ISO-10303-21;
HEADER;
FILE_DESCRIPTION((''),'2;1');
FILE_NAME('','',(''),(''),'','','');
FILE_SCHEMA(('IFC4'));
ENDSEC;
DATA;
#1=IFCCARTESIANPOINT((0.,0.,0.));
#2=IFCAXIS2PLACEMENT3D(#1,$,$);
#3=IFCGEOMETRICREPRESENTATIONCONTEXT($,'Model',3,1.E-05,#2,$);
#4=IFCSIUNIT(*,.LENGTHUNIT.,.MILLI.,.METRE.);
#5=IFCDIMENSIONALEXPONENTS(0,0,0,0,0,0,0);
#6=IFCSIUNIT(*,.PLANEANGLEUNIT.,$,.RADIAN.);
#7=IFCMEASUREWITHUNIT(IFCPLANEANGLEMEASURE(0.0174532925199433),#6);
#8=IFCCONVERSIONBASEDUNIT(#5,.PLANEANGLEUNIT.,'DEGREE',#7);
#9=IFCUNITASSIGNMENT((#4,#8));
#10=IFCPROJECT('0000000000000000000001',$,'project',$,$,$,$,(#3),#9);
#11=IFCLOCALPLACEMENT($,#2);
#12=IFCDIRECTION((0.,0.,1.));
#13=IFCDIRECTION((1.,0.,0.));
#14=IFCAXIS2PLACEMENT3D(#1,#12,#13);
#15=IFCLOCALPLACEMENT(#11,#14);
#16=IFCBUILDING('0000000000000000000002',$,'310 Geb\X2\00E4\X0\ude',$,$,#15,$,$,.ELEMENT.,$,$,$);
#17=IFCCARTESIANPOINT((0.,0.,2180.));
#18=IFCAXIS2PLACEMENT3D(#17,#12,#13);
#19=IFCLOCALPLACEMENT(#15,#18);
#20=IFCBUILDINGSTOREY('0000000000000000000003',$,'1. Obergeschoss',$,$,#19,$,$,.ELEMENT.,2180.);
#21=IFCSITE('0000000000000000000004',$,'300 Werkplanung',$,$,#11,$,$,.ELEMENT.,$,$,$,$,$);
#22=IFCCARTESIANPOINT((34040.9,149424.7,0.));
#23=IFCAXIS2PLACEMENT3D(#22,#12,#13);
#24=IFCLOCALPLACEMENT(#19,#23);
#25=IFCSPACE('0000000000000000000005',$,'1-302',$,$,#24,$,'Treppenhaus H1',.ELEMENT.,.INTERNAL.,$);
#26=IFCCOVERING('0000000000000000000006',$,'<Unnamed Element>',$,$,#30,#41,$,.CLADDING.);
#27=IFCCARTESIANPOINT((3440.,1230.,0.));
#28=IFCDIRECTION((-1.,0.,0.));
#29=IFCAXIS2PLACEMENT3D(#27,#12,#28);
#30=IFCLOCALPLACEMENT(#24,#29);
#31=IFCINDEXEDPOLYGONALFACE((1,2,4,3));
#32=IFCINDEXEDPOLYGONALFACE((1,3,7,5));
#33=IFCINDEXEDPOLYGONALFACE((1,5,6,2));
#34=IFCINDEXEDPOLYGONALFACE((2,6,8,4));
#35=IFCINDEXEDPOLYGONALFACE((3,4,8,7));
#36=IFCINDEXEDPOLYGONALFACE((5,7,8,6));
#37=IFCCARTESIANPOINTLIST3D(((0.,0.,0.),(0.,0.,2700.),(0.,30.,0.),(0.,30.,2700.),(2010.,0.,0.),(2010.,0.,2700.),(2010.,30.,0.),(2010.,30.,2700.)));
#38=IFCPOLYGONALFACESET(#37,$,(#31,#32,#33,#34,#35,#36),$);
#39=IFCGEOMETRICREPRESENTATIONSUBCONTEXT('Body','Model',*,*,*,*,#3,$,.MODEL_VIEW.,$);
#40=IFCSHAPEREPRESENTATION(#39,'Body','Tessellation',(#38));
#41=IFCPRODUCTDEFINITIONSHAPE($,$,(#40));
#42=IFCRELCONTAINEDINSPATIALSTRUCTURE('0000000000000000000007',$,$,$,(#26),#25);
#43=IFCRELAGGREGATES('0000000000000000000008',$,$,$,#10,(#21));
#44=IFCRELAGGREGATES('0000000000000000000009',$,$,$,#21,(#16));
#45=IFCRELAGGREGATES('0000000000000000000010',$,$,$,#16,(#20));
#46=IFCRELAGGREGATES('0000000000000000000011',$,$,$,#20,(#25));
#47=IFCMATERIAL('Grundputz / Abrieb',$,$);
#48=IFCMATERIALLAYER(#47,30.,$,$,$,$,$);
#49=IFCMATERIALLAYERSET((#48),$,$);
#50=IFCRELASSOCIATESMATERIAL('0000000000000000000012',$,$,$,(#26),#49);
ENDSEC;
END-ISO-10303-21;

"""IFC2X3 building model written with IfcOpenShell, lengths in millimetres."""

from ifc_helpers import new_model, entity, si_unit, converted_unit, frame, frame_2d, origin, origin_with_axes, place, context, subcontext, project, spatial, rectangle, extrude, material, layer, layer_set, layer_usage, element, save


model = new_model("IFC2X3")

# Units and contexts
model_context = context("Model", 3, precision=1e-05, world=origin())
body_context = subcontext(model_context, "Body", "Model", "MODEL_VIEW")
ifc_project = project(units=[si_unit("LENGTHUNIT", "METRE", prefix="MILLI"), converted_unit("PLANEANGLEUNIT", "DEGREE", entity("IfcPlaneAngleMeasure", 0.0174532925199433), si_unit("PLANEANGLEUNIT", "RADIAN"), dimensions=[0, 0, 0, 0, 0, 0, 0])], contexts=[model_context])

# Site, building, storey
site_placement = place(None, origin())
site = spatial("IfcSite", under=ifc_project, at=site_placement, Name="300 Werkplanung", CompositionType="ELEMENT")
building_placement = place(site_placement, origin_with_axes())
building = spatial("IfcBuilding", under=site, at=building_placement, Name="310 Gebäude", CompositionType="ELEMENT")
storey_placement = place(building_placement, frame((0.0, 0.0, 2180.0), z_axis=(0.0, 0.0, 1.0), x_axis=(1.0, 0.0, 0.0)))
storey = spatial("IfcBuildingStorey", under=building, at=storey_placement, Name="1. Obergeschoss", CompositionType="ELEMENT", Elevation=2180.0)

# Shared definitions
space_1_placement = place(storey_placement, frame((34040.9, 149424.7, 0.0), z_axis=(0.0, 0.0, 1.0), x_axis=(1.0, 0.0, 0.0)))
space_1 = spatial("IfcSpace", under=storey, at=space_1_placement, Name="1-302", LongName="Treppenhaus H1", CompositionType="ELEMENT", InteriorOrExteriorSpace="INTERNAL")

# Covering
ifc_material_1 = material(Name="Grundputz / Abrieb")
ifc_layer_1 = layer(ifc_material_1, 30.0)
ifc_layer_set_1 = layer_set([ifc_layer_1])
ifc_layer_usage_1 = layer_usage(ifc_layer_set_1, "AXIS3", "POSITIVE", 0.0)
covering_1_placement = place(space_1_placement, frame((3440.0, 1230.0, 0.0), z_axis=(0.0, 0.0, 1.0), x_axis=(-1.0, 0.0, 0.0)))
element("IfcCovering", 1, at=covering_1_placement, inside=space_1, material=ifc_layer_usage_1, Name="<Unnamed Element>", PredefinedType="CLADDING", context=body_context, shape_type="SweptSolid", body=[
    extrude(rectangle(XDim=2700.0, YDim=2010.0, at=frame_2d((-1005.0, 1350.0), x_axis=(0.0, 1.0))), frame((2010.0, 0.0, 2700.0), z_axis=(0.0, 1.0, 0.0), x_axis=(1.0, 0.0, 0.0)), (0.0, 0.0, 1.0), 30.0),
])

save(model, "model.ifc")
